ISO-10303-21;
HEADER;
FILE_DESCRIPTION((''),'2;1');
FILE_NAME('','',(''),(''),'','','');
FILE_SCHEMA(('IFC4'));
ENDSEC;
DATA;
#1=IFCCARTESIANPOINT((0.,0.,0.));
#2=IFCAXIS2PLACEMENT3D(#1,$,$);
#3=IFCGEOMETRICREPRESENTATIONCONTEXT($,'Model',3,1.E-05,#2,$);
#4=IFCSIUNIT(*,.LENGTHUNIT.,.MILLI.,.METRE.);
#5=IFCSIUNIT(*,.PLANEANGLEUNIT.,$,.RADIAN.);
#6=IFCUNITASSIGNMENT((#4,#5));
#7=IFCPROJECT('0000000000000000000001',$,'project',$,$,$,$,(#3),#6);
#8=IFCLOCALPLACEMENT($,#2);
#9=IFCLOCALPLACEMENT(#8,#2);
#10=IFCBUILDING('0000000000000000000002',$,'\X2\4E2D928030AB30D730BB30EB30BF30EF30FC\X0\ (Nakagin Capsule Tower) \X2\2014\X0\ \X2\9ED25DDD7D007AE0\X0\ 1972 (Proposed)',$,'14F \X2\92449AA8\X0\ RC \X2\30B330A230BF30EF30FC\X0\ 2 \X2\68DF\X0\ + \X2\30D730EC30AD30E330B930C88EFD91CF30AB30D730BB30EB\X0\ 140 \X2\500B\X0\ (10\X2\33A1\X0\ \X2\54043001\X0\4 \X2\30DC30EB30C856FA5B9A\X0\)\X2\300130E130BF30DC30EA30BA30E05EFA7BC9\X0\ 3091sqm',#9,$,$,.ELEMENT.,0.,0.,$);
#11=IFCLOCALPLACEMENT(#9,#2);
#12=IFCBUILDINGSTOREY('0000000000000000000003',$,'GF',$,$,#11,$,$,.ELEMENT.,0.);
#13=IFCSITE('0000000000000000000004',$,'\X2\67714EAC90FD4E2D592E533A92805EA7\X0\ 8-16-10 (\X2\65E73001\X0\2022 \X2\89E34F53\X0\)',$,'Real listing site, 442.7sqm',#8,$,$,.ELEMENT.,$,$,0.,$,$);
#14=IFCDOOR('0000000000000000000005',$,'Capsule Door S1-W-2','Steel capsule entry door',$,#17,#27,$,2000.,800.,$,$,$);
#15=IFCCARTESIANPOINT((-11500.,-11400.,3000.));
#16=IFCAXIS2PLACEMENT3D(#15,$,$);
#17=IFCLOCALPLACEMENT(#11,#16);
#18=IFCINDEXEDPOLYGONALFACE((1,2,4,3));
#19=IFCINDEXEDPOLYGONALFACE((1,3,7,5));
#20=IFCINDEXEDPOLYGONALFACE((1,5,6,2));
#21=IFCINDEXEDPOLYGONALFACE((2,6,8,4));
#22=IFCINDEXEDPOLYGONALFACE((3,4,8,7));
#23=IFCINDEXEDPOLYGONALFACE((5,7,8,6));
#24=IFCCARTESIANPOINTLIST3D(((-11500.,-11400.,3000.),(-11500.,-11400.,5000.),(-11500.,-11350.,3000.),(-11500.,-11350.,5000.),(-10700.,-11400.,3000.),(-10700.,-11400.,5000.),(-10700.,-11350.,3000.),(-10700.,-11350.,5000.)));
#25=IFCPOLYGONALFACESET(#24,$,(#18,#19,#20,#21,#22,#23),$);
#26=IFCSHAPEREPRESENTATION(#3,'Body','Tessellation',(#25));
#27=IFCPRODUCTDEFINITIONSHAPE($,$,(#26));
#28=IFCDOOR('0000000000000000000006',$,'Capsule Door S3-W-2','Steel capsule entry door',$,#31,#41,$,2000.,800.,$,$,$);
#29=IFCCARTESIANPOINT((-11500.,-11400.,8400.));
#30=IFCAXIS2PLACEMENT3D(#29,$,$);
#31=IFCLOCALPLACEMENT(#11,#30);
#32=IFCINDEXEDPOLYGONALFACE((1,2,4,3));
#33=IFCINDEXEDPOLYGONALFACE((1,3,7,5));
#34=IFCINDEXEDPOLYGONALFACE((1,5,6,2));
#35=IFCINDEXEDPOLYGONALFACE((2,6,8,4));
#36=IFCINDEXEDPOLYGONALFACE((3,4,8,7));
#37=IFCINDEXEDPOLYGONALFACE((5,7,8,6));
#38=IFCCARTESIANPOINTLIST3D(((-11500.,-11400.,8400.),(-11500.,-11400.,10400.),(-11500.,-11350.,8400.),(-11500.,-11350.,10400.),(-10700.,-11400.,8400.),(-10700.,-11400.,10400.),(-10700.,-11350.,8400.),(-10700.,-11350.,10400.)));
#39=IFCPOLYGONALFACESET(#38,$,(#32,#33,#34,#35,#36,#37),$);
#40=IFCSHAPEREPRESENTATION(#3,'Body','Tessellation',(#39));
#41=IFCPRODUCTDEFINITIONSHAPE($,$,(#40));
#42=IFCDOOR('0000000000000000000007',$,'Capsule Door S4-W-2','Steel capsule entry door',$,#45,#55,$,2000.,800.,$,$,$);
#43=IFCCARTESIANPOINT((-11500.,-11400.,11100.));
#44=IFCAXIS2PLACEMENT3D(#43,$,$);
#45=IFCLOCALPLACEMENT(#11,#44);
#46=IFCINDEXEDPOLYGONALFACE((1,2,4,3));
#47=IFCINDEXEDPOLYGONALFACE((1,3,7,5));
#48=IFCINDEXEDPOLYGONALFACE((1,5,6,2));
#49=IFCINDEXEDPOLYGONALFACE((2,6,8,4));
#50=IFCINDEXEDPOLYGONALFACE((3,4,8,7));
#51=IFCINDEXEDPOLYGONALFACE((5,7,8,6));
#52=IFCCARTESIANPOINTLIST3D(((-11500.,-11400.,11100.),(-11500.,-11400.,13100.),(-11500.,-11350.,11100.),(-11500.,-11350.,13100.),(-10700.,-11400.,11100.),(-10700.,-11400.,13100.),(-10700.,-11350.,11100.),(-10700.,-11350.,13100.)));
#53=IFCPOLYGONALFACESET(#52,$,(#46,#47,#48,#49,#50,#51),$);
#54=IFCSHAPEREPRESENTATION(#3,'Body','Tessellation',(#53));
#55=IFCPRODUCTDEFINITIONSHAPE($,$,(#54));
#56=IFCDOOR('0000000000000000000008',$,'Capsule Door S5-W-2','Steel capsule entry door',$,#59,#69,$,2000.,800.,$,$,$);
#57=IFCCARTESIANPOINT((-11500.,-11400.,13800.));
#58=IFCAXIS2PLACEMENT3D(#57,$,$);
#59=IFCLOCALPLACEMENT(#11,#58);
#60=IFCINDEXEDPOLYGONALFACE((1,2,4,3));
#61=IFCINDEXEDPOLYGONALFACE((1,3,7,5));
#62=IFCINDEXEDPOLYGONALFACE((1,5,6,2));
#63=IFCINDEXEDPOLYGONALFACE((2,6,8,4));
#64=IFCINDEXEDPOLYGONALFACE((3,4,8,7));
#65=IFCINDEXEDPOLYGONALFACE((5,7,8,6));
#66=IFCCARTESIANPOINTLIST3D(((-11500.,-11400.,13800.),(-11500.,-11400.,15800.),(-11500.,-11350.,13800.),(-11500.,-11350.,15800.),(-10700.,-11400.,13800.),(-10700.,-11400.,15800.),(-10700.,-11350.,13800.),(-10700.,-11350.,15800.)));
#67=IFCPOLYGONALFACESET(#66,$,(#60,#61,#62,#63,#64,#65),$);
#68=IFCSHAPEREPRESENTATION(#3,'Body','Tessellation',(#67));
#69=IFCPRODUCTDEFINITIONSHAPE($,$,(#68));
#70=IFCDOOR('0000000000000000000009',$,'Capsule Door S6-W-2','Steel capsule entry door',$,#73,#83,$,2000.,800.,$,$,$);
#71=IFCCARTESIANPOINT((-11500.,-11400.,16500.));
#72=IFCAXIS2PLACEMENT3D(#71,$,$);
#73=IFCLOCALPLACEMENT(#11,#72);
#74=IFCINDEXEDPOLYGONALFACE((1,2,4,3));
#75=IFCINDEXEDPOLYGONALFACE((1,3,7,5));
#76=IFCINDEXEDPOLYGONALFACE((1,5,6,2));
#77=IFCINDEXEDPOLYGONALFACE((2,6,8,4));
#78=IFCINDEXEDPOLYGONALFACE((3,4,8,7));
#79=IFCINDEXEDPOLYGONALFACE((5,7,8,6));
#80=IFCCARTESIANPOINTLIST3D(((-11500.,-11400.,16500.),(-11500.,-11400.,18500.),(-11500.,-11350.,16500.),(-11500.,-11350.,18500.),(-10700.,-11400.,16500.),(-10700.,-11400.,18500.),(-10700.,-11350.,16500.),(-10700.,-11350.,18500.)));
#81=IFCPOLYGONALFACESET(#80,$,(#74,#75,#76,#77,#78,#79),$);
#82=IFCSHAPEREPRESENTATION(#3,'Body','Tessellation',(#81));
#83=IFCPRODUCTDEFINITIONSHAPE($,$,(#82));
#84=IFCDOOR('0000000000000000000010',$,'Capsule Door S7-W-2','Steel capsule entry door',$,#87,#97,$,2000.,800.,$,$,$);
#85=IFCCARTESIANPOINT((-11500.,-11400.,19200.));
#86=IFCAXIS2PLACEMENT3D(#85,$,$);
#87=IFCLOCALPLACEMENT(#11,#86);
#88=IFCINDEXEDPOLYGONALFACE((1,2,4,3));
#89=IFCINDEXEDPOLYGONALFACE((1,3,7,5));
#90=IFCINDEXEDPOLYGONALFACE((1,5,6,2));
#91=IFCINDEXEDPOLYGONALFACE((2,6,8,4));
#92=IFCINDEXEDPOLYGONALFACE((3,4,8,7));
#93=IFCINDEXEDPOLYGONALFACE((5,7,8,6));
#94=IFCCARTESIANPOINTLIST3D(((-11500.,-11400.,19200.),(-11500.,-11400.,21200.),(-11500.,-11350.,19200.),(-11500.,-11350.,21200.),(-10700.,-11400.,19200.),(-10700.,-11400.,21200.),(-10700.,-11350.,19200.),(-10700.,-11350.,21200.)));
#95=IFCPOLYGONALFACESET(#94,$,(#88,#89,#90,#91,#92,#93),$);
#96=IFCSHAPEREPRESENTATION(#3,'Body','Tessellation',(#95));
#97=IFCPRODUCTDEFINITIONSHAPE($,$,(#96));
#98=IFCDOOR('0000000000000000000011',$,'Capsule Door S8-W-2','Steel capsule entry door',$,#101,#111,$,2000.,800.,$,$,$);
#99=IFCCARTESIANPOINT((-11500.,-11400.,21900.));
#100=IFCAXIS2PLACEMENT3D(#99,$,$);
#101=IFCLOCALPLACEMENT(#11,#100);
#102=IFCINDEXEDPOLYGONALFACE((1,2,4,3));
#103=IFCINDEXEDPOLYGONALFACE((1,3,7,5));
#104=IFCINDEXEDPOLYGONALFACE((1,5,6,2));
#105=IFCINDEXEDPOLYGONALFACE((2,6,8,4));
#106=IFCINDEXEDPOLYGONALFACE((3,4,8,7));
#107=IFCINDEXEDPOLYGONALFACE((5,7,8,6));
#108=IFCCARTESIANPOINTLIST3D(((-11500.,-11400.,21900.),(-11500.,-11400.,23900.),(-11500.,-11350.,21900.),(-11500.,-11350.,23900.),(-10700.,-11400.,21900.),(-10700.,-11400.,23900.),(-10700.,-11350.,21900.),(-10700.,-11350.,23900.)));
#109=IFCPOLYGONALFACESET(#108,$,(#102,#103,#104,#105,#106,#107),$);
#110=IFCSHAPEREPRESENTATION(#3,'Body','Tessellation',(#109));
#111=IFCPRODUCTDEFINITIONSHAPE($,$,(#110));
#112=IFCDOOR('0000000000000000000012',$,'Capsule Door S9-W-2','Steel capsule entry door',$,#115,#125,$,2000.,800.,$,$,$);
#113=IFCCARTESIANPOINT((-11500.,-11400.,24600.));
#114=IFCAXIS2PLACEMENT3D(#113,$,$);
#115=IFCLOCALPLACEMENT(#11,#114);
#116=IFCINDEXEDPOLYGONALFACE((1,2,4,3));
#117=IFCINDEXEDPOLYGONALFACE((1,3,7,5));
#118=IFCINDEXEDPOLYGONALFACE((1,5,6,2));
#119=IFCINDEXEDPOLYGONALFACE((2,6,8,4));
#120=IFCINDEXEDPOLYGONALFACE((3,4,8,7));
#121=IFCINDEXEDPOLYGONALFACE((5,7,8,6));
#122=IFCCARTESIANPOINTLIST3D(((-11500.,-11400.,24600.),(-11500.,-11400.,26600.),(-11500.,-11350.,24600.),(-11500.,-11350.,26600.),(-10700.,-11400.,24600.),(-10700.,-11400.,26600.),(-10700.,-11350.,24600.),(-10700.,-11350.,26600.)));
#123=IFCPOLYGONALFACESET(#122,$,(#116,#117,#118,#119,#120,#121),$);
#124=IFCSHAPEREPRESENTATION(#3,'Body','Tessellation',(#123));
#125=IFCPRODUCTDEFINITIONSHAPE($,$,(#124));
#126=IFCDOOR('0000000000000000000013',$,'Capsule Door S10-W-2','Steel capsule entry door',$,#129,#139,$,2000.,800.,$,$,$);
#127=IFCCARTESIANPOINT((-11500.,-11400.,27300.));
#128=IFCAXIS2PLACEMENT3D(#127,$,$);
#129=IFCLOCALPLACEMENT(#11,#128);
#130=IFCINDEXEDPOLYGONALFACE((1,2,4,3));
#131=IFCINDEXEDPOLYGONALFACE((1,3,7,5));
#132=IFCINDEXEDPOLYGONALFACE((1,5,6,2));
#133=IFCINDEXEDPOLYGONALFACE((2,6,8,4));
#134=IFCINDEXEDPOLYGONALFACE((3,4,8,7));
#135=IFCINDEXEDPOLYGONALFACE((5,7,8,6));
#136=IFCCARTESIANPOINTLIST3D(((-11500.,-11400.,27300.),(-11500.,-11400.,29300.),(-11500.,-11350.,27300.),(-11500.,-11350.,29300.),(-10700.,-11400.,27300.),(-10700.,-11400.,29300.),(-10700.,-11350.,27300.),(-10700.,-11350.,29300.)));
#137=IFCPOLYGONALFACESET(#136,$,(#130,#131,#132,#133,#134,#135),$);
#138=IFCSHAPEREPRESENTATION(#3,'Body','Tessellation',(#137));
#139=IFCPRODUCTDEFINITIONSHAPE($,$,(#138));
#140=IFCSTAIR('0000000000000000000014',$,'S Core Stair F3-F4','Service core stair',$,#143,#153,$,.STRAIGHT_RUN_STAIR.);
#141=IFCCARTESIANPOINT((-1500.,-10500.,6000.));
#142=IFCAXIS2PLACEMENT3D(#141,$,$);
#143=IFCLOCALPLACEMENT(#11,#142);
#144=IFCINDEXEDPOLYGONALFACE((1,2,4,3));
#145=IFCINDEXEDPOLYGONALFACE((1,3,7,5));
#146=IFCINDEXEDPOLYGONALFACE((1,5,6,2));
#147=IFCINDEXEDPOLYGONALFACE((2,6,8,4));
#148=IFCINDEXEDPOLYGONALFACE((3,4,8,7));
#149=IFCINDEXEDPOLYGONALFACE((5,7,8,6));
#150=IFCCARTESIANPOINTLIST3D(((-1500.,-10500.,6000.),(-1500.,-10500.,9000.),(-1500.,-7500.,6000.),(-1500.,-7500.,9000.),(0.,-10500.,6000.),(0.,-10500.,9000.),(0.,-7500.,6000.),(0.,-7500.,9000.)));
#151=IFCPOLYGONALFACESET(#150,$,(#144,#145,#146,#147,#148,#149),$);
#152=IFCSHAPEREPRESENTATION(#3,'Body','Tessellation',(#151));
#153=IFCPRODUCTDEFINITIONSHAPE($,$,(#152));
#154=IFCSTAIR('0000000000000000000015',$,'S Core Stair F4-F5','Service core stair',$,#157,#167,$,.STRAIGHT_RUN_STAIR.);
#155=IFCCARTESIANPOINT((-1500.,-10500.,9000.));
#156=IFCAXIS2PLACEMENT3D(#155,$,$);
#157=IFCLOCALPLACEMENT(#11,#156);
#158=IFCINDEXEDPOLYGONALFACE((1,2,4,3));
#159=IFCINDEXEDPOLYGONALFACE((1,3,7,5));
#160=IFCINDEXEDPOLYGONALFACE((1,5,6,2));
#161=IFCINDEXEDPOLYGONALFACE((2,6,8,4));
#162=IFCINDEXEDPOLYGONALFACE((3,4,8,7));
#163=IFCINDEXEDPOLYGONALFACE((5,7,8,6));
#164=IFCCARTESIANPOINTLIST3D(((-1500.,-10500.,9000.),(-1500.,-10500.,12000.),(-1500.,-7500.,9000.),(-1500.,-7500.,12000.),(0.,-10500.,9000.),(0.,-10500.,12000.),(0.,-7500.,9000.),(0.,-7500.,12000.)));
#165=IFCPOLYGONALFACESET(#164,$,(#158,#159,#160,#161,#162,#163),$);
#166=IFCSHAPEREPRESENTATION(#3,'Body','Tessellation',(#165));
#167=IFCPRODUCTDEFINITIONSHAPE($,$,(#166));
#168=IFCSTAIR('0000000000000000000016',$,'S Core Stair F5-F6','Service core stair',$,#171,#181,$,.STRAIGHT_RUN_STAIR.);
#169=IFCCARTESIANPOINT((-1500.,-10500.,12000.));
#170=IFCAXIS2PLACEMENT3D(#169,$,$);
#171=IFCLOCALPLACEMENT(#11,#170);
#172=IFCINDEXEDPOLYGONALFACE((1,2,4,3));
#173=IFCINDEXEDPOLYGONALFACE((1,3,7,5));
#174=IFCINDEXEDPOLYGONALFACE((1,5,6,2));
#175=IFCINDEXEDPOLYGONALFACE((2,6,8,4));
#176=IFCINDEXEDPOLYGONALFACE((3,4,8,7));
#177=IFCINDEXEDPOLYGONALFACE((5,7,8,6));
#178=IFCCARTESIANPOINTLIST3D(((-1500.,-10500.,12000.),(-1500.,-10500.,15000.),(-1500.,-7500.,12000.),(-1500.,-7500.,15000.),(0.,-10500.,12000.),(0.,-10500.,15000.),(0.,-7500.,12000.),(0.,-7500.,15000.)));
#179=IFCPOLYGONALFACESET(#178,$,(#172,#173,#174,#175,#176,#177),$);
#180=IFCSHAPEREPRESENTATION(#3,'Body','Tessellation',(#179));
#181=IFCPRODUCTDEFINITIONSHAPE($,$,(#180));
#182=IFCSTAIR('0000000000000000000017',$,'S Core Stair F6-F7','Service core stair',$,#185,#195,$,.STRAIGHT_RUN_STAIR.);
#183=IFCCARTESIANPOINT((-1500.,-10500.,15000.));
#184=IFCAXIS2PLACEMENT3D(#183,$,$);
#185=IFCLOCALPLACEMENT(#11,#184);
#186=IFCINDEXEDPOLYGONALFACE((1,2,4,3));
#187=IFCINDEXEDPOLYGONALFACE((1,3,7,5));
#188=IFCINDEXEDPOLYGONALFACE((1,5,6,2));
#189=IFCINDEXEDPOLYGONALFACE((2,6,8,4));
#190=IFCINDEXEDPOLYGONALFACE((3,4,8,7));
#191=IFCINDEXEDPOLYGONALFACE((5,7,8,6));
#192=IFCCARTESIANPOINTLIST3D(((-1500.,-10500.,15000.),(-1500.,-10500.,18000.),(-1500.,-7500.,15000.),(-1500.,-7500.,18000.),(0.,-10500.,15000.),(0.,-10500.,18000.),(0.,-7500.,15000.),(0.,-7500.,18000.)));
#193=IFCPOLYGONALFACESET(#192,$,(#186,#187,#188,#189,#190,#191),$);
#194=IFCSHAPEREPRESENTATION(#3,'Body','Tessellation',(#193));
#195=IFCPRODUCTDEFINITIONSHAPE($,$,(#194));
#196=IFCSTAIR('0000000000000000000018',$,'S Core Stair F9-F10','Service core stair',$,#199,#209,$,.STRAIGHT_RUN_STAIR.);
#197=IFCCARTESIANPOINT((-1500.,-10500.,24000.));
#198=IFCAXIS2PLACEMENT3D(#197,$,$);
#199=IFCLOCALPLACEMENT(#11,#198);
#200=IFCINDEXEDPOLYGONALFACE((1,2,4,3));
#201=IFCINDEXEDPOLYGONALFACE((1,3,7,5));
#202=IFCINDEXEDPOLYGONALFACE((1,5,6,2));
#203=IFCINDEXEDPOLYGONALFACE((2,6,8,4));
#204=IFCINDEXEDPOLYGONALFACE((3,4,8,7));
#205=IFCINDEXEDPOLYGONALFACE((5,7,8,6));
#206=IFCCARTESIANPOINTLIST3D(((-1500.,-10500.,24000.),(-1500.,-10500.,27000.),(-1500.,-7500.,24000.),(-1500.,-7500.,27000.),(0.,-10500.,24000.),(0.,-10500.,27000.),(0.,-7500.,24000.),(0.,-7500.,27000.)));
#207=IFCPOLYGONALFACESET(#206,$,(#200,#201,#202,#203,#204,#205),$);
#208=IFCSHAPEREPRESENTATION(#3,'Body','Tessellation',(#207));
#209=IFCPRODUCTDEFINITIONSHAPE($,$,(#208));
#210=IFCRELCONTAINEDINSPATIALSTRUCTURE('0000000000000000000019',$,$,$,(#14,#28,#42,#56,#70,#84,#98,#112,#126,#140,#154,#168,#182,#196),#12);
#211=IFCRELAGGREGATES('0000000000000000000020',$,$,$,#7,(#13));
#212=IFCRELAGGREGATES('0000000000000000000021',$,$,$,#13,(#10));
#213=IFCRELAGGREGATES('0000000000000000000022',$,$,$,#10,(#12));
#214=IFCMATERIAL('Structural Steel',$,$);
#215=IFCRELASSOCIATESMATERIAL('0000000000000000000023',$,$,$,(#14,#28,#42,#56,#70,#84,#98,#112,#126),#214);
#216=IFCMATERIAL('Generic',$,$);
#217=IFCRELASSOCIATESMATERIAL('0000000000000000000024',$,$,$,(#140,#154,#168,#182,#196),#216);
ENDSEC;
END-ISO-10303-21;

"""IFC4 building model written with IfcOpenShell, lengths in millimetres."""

from ifc_helpers import new_model, si_unit, frame, frame_2d, origin, place, context, project, spatial, rectangle, extrude, material, element, save


model = new_model("IFC4")

# Units and contexts
model_context = context("Model", 3, precision=1e-05, world=origin())
ifc_project = project(units=[si_unit("LENGTHUNIT", "METRE", prefix="MILLI"), si_unit("PLANEANGLEUNIT", "RADIAN")], contexts=[model_context])

# Site, building, storey
site_placement = place(None, origin())
site = spatial("IfcSite", under=ifc_project, at=site_placement, Name="東京都中央区銀座 8-16-10 (旧、2022 解体)", ObjectType="Real listing site, 442.7sqm", CompositionType="ELEMENT", RefElevation=0.0)
building_placement = place(site_placement, origin())
building = spatial("IfcBuilding", under=site, at=building_placement, Name="中銀カプセルタワー (Nakagin Capsule Tower) — 黒川紀章 1972 (Proposed)", ObjectType="14F 鉄骨 RC コアタワー 2 棟 + プレキャスト軽量カプセル 140 個 (10㎡ 各、4 ボルト固定)、メタボリズム建築 3091sqm", CompositionType="ELEMENT", ElevationOfRefHeight=0.0, ElevationOfTerrain=0.0)
storey_placement = place(building_placement, origin())
storey = spatial("IfcBuildingStorey", under=building, at=storey_placement, Name="GF", CompositionType="ELEMENT", Elevation=0.0)

# Doors
ifc_material_1 = material(Name="Structural Steel")
door_1_placement = place(storey_placement, frame((-11500.0, -11400.0, 3000.0)))
element("IfcDoor", 1, at=door_1_placement, inside=storey, material=ifc_material_1, Name="Capsule Door S1-W-2", Description="Steel capsule entry door", OverallHeight=2000.0, OverallWidth=800.0, context=model_context, shape_type="SweptSolid", body=[
    extrude(rectangle(XDim=800.0, YDim=50.0, at=frame_2d((400.0, 25.0))), frame((-11500.0, -11400.0, 3000.0)), (0.0, 0.0, 1.0), 2000.0),
])
door_2_placement = place(storey_placement, frame((-11500.0, -11400.0, 8400.0)))
element("IfcDoor", 2, at=door_2_placement, inside=storey, material=ifc_material_1, Name="Capsule Door S3-W-2", Description="Steel capsule entry door", OverallHeight=2000.0, OverallWidth=800.0, context=model_context, shape_type="SweptSolid", body=[
    extrude(rectangle(XDim=800.0, YDim=50.0, at=frame_2d((400.0, 25.0))), frame((-11500.0, -11400.0, 8400.0)), (0.0, 0.0, 1.0), 2000.0),
])
door_3_placement = place(storey_placement, frame((-11500.0, -11400.0, 11100.0)))
element("IfcDoor", 3, at=door_3_placement, inside=storey, material=ifc_material_1, Name="Capsule Door S4-W-2", Description="Steel capsule entry door", OverallHeight=2000.0, OverallWidth=800.0, context=model_context, shape_type="SweptSolid", body=[
    extrude(rectangle(XDim=800.0, YDim=50.0, at=frame_2d((400.0, 25.0))), frame((-11500.0, -11400.0, 11100.0)), (0.0, 0.0, 1.0), 2000.0),
])
door_4_placement = place(storey_placement, frame((-11500.0, -11400.0, 13800.0)))
element("IfcDoor", 4, at=door_4_placement, inside=storey, material=ifc_material_1, Name="Capsule Door S5-W-2", Description="Steel capsule entry door", OverallHeight=2000.0, OverallWidth=800.0, context=model_context, shape_type="SweptSolid", body=[
    extrude(rectangle(XDim=800.0, YDim=50.0, at=frame_2d((400.0, 25.0))), frame((-11500.0, -11400.0, 13800.0)), (0.0, 0.0, 1.0), 2000.0),
])
door_5_placement = place(storey_placement, frame((-11500.0, -11400.0, 16500.0)))
element("IfcDoor", 5, at=door_5_placement, inside=storey, material=ifc_material_1, Name="Capsule Door S6-W-2", Description="Steel capsule entry door", OverallHeight=2000.0, OverallWidth=800.0, context=model_context, shape_type="SweptSolid", body=[
    extrude(rectangle(XDim=800.0, YDim=50.0, at=frame_2d((400.0, 25.0))), frame((-11500.0, -11400.0, 16500.0)), (0.0, 0.0, 1.0), 2000.0),
])
door_6_placement = place(storey_placement, frame((-11500.0, -11400.0, 19200.0)))
element("IfcDoor", 6, at=door_6_placement, inside=storey, material=ifc_material_1, Name="Capsule Door S7-W-2", Description="Steel capsule entry door", OverallHeight=2000.0, OverallWidth=800.0, context=model_context, shape_type="SweptSolid", body=[
    extrude(rectangle(XDim=800.0, YDim=50.0, at=frame_2d((400.0, 25.0))), frame((-11500.0, -11400.0, 19200.0)), (0.0, 0.0, 1.0), 2000.0),
])
door_7_placement = place(storey_placement, frame((-11500.0, -11400.0, 21900.0)))
element("IfcDoor", 7, at=door_7_placement, inside=storey, material=ifc_material_1, Name="Capsule Door S8-W-2", Description="Steel capsule entry door", OverallHeight=2000.0, OverallWidth=800.0, context=model_context, shape_type="SweptSolid", body=[
    extrude(rectangle(XDim=800.0, YDim=50.0, at=frame_2d((400.0, 25.0))), frame((-11500.0, -11400.0, 21900.0)), (0.0, 0.0, 1.0), 2000.0),
])
door_8_placement = place(storey_placement, frame((-11500.0, -11400.0, 24600.0)))
element("IfcDoor", 8, at=door_8_placement, inside=storey, material=ifc_material_1, Name="Capsule Door S9-W-2", Description="Steel capsule entry door", OverallHeight=2000.0, OverallWidth=800.0, context=model_context, shape_type="SweptSolid", body=[
    extrude(rectangle(XDim=800.0, YDim=50.0, at=frame_2d((400.0, 25.0))), frame((-11500.0, -11400.0, 24600.0)), (0.0, 0.0, 1.0), 2000.0),
])
door_9_placement = place(storey_placement, frame((-11500.0, -11400.0, 27300.0)))
element("IfcDoor", 9, at=door_9_placement, inside=storey, material=ifc_material_1, Name="Capsule Door S10-W-2", Description="Steel capsule entry door", OverallHeight=2000.0, OverallWidth=800.0, context=model_context, shape_type="SweptSolid", body=[
    extrude(rectangle(XDim=800.0, YDim=50.0, at=frame_2d((400.0, 25.0))), frame((-11500.0, -11400.0, 27300.0)), (0.0, 0.0, 1.0), 2000.0),
])

# Stairs
ifc_material_2 = material(Name="Generic")
stair_1_placement = place(storey_placement, frame((-1500.0, -10500.0, 6000.0)))
element("IfcStair", 10, at=stair_1_placement, inside=storey, material=ifc_material_2, Name="S Core Stair F3-F4", Description="Service core stair", PredefinedType="STRAIGHT_RUN_STAIR", context=model_context, shape_type="SweptSolid", body=[
    extrude(rectangle(XDim=1500.0, YDim=3000.0, at=frame_2d((750.0, 1500.0))), frame((-1500.0, -10500.0, 6000.0)), (0.0, 0.0, 1.0), 3000.0),
])
stair_2_placement = place(storey_placement, frame((-1500.0, -10500.0, 9000.0)))
element("IfcStair", 11, at=stair_2_placement, inside=storey, material=ifc_material_2, Name="S Core Stair F4-F5", Description="Service core stair", PredefinedType="STRAIGHT_RUN_STAIR", context=model_context, shape_type="SweptSolid", body=[
    extrude(rectangle(XDim=1500.0, YDim=3000.0, at=frame_2d((750.0, 1500.0))), frame((-1500.0, -10500.0, 9000.0)), (0.0, 0.0, 1.0), 3000.0),
])
stair_3_placement = place(storey_placement, frame((-1500.0, -10500.0, 12000.0)))
element("IfcStair", 12, at=stair_3_placement, inside=storey, material=ifc_material_2, Name="S Core Stair F5-F6", Description="Service core stair", PredefinedType="STRAIGHT_RUN_STAIR", context=model_context, shape_type="SweptSolid", body=[
    extrude(rectangle(XDim=1500.0, YDim=3000.0, at=frame_2d((750.0, 1500.0))), frame((-1500.0, -10500.0, 12000.0)), (0.0, 0.0, 1.0), 3000.0),
])
stair_4_placement = place(storey_placement, frame((-1500.0, -10500.0, 15000.0)))
element("IfcStair", 13, at=stair_4_placement, inside=storey, material=ifc_material_2, Name="S Core Stair F6-F7", Description="Service core stair", PredefinedType="STRAIGHT_RUN_STAIR", context=model_context, shape_type="SweptSolid", body=[
    extrude(rectangle(XDim=1500.0, YDim=3000.0, at=frame_2d((750.0, 1500.0))), frame((-1500.0, -10500.0, 15000.0)), (0.0, 0.0, 1.0), 3000.0),
])
stair_5_placement = place(storey_placement, frame((-1500.0, -10500.0, 24000.0)))
element("IfcStair", 14, at=stair_5_placement, inside=storey, material=ifc_material_2, Name="S Core Stair F9-F10", Description="Service core stair", PredefinedType="STRAIGHT_RUN_STAIR", context=model_context, shape_type="SweptSolid", body=[
    extrude(rectangle(XDim=1500.0, YDim=3000.0, at=frame_2d((750.0, 1500.0))), frame((-1500.0, -10500.0, 24000.0)), (0.0, 0.0, 1.0), 3000.0),
])

save(model, "model.ifc")
